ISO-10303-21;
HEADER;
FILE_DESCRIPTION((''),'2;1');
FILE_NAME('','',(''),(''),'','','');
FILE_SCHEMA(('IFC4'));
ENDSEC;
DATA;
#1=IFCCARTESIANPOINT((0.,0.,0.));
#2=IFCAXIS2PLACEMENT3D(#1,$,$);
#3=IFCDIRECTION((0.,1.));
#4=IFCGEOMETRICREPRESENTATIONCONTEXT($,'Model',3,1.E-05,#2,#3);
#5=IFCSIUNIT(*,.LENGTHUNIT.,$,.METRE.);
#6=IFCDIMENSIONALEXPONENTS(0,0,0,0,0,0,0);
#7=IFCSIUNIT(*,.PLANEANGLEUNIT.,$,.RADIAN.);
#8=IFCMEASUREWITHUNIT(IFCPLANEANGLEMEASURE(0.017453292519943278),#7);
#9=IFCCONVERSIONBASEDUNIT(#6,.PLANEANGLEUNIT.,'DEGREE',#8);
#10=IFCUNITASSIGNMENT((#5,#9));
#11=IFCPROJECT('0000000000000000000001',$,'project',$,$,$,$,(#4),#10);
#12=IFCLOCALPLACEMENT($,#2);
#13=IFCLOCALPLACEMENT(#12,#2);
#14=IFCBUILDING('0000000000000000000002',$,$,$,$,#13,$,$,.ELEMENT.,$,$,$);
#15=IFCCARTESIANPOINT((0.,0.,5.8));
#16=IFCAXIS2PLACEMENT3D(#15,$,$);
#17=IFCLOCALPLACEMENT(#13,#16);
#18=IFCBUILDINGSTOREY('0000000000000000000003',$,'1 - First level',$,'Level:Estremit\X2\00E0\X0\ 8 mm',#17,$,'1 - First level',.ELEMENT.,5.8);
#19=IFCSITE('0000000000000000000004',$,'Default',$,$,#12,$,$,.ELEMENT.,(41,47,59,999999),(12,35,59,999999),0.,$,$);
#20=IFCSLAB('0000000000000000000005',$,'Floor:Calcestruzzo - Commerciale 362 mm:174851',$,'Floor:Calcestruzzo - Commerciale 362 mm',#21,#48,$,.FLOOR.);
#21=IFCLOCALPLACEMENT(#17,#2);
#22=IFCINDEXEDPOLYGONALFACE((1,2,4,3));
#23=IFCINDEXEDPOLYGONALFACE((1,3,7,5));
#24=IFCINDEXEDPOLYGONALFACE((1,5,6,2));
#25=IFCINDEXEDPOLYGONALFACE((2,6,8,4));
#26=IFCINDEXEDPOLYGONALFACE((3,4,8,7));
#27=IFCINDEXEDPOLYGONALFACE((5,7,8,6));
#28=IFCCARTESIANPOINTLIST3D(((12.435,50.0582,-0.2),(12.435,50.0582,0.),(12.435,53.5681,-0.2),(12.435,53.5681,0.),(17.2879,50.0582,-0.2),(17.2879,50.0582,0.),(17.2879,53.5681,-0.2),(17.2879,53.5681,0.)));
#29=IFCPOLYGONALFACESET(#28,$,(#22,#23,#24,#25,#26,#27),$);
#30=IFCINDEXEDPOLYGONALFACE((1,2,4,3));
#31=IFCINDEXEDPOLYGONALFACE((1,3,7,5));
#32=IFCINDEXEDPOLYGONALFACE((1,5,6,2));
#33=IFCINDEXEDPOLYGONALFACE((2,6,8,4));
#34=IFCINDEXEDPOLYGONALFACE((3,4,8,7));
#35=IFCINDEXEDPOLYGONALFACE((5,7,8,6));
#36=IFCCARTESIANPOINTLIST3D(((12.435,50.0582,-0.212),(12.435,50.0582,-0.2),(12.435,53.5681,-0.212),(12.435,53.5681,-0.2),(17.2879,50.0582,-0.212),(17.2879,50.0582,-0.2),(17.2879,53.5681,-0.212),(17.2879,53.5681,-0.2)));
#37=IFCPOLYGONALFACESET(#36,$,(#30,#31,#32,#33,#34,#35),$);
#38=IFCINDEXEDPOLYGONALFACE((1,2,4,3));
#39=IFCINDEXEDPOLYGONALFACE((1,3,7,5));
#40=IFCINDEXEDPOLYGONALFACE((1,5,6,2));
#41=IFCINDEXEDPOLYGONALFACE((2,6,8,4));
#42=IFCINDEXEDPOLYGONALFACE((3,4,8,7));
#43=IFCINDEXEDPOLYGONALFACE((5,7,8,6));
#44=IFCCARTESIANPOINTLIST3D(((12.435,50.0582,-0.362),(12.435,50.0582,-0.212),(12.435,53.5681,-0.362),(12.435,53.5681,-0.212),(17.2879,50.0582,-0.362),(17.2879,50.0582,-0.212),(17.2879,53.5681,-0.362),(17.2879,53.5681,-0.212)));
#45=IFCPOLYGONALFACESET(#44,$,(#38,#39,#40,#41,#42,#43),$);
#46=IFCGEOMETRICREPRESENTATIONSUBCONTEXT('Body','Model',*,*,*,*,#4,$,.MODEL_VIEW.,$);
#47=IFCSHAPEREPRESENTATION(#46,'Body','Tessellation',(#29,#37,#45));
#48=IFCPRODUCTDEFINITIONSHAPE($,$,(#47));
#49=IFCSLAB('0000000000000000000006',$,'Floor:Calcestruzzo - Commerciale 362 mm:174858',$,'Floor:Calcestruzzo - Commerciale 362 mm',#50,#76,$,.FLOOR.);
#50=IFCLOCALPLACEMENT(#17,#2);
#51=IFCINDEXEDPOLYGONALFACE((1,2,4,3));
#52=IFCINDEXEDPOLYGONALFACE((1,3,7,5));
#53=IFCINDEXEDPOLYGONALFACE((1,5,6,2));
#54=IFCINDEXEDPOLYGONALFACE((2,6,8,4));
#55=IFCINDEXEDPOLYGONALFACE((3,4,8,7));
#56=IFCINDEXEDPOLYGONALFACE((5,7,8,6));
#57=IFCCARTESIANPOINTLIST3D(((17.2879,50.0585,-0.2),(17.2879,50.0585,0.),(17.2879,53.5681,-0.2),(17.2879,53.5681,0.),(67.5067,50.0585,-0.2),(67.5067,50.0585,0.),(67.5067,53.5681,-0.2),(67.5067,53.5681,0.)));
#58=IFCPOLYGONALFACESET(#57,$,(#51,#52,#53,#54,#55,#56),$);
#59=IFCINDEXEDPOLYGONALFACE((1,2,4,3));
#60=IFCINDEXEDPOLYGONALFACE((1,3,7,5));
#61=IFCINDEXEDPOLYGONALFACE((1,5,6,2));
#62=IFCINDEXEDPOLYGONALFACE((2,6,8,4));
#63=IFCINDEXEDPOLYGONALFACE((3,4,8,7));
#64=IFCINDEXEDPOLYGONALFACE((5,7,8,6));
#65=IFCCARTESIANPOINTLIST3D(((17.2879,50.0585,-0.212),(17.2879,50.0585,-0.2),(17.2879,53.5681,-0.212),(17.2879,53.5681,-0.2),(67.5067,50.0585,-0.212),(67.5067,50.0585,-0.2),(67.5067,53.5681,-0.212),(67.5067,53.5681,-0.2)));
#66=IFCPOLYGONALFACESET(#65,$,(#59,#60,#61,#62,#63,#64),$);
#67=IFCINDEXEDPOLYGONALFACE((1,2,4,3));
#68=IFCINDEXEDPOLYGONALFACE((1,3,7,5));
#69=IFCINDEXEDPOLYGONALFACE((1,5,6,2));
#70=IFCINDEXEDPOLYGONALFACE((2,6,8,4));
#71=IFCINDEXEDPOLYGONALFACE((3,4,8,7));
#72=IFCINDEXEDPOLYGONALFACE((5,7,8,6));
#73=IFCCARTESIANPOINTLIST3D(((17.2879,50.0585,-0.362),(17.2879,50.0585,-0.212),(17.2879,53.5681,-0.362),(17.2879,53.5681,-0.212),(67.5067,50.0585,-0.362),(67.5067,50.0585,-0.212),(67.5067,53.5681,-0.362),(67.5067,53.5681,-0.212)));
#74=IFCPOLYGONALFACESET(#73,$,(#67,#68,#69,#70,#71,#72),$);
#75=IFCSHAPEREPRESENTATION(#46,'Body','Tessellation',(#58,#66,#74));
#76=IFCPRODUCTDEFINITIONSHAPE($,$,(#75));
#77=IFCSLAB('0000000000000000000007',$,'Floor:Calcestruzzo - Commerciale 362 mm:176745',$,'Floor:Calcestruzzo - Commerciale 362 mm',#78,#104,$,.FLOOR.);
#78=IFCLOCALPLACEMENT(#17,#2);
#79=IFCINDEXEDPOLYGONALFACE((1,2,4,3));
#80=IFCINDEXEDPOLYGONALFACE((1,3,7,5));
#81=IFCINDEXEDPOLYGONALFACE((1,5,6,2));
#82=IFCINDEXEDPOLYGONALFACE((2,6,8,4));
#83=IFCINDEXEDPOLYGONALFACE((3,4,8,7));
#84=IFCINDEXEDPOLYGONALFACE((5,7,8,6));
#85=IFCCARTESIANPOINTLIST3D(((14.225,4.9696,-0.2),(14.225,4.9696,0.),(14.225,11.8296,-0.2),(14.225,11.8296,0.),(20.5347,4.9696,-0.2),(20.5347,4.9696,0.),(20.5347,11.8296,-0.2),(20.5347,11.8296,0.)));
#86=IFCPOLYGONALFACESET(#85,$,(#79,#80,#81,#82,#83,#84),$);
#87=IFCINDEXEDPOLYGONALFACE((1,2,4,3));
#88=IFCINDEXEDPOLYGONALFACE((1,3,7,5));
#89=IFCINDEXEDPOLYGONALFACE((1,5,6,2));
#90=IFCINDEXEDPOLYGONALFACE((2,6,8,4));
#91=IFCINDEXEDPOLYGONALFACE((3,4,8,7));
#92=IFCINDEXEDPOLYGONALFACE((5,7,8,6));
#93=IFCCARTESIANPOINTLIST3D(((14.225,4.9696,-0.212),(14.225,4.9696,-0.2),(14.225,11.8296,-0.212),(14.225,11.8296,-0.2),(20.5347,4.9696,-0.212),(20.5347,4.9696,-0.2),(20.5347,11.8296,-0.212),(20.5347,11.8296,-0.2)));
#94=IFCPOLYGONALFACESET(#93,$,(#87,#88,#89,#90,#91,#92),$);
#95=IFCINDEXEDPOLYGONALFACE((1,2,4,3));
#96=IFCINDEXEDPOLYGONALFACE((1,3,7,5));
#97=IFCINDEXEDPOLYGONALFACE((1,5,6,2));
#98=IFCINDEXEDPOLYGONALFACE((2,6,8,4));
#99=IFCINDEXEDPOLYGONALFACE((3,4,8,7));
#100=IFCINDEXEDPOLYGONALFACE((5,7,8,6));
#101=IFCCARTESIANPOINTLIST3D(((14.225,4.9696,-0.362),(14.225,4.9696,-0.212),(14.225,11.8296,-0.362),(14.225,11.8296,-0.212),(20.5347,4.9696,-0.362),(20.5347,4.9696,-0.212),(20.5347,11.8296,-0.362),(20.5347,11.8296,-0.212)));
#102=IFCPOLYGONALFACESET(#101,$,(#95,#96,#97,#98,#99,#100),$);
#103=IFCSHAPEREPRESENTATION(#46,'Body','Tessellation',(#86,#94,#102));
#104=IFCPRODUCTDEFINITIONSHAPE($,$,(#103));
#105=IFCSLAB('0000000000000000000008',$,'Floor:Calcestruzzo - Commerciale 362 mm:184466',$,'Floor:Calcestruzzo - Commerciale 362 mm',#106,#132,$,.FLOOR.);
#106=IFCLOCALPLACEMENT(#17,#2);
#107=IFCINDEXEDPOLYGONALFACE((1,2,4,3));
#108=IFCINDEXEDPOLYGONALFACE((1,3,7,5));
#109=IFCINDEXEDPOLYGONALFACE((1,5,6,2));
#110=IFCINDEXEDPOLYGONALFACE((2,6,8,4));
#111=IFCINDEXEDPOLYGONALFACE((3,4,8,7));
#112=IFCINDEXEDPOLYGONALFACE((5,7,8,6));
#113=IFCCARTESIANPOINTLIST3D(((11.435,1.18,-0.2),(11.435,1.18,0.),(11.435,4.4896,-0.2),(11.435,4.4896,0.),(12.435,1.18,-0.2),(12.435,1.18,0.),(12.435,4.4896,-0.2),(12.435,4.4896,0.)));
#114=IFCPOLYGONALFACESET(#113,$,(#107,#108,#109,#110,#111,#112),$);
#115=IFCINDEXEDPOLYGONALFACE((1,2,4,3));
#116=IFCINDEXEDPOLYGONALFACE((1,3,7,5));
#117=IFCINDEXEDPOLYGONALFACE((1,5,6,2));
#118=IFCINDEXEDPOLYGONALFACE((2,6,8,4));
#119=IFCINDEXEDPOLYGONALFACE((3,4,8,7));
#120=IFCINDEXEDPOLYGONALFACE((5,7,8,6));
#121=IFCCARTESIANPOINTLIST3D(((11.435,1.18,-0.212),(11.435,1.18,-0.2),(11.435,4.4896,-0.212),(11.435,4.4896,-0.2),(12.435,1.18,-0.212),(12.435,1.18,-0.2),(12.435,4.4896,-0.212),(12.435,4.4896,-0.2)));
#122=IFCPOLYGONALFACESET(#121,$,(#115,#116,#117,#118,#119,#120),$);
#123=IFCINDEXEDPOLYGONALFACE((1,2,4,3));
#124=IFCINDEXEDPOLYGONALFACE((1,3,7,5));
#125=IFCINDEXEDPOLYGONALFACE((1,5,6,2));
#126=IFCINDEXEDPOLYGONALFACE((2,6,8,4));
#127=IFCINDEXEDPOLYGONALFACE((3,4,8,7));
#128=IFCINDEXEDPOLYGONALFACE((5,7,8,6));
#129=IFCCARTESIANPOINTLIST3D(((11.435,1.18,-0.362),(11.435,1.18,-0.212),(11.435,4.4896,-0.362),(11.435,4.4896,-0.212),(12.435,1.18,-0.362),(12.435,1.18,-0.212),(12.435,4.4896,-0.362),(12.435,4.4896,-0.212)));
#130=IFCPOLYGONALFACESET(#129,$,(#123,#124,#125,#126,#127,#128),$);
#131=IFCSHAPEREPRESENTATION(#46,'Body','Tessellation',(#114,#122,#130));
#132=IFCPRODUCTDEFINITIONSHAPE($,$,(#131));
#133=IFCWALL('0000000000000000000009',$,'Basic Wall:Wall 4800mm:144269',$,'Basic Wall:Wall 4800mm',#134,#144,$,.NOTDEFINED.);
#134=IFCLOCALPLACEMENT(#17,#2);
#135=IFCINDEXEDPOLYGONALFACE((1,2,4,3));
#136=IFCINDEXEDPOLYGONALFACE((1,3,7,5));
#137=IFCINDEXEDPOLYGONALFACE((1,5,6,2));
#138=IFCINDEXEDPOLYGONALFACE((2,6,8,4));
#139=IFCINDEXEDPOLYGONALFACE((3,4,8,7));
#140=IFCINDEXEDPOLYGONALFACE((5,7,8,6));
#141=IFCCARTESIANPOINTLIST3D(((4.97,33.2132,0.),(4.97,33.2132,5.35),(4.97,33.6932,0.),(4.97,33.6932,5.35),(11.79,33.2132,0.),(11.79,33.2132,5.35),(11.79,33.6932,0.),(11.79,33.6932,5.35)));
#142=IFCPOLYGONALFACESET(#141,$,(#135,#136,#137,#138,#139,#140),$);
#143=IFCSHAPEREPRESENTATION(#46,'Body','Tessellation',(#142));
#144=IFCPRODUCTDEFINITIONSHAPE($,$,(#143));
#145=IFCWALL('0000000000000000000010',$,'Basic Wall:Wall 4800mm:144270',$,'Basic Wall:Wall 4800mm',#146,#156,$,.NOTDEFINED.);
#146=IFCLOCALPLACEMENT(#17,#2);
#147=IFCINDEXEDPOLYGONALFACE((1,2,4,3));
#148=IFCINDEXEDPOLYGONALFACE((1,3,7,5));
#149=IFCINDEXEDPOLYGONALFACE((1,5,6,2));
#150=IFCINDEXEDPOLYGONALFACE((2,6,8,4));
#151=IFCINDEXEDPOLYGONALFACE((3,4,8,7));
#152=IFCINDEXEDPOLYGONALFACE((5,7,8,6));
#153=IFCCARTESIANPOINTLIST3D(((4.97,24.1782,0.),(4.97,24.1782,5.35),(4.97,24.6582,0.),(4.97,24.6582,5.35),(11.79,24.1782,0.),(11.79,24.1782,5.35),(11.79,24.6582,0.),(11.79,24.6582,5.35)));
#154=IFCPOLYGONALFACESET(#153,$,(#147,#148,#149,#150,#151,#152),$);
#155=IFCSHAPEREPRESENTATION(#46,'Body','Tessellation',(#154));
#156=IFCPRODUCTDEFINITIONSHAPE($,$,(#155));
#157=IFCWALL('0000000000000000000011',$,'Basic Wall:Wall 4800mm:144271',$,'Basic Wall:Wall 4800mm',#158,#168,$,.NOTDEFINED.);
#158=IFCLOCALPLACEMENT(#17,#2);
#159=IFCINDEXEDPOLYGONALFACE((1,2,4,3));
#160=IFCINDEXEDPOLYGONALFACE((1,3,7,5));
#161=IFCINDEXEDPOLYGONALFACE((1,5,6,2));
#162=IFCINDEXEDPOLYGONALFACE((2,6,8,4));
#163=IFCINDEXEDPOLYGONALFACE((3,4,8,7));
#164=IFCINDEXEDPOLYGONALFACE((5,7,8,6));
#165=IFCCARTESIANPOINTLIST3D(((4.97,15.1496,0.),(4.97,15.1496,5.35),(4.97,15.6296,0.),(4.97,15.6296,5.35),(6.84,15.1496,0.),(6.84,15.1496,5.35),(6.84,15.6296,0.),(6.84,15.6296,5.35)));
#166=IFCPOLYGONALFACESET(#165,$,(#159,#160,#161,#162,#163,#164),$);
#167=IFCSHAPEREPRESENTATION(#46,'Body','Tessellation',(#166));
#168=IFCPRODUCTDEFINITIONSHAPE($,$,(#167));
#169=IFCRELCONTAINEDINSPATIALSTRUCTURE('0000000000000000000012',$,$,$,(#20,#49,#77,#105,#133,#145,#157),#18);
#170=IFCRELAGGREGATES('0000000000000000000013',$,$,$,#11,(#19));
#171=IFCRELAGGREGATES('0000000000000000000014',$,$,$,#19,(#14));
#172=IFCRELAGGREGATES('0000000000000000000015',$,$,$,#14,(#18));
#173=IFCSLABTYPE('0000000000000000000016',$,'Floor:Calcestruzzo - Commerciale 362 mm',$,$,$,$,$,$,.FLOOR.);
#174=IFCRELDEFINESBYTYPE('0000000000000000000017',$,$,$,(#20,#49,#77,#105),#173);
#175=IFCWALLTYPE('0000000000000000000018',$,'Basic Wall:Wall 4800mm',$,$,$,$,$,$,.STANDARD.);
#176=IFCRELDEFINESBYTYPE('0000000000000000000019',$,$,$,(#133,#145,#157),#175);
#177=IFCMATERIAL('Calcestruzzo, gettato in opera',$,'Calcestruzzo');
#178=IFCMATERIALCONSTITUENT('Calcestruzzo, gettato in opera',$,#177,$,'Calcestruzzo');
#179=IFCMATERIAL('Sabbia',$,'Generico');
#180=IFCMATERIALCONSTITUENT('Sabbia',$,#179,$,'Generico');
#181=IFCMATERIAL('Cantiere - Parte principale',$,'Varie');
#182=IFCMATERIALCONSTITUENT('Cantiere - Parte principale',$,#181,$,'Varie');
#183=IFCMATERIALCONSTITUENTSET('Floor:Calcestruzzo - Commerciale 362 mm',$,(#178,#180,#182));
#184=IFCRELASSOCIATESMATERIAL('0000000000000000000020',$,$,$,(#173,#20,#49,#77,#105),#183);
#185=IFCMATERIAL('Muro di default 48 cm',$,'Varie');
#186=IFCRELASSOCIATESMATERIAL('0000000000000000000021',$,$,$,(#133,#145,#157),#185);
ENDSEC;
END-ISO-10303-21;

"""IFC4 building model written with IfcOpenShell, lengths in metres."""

from ifc_helpers import new_model, entity, si_unit, converted_unit, direction, frame, origin, place, context, subcontext, project, spatial, indexed_curve, outline, extrude, material, constituent, constituent_set, type_object, element, save


model = new_model("IFC4")

# Units and contexts
model_context = context("Model", 3, precision=1e-05, world=origin(), true_north=direction((0.0, 1.0)))
body_context = subcontext(model_context, "Body", "Model", "MODEL_VIEW")
ifc_project = project(units=[si_unit("LENGTHUNIT", "METRE"), converted_unit("PLANEANGLEUNIT", "DEGREE", entity("IfcPlaneAngleMeasure", 0.017453292519943278), si_unit("PLANEANGLEUNIT", "RADIAN"), dimensions=[0, 0, 0, 0, 0, 0, 0])], contexts=[model_context])

# Site, building, storey
site_placement = place(None, origin())
site = spatial("IfcSite", under=ifc_project, at=site_placement, Name="Default", CompositionType="ELEMENT", RefLatitude=(41, 47, 59, 999999), RefLongitude=(12, 35, 59, 999999), RefElevation=0.0)
building_placement = place(site_placement, origin())
building = spatial("IfcBuilding", under=site, at=building_placement, CompositionType="ELEMENT")
storey_placement = place(building_placement, frame((0.0, 0.0, 5.8)))
storey = spatial("IfcBuildingStorey", under=building, at=storey_placement, Name="1 - First level", ObjectType="Level:Estremità 8 mm", LongName="1 - First level", CompositionType="ELEMENT", Elevation=5.8)

# Slabs
ifc_material_1 = material(Name="Calcestruzzo, gettato in opera", Category="Calcestruzzo")
ifc_constituent_1 = constituent(ifc_material_1, Name="Calcestruzzo, gettato in opera", Category="Calcestruzzo")
ifc_material_2 = material(Name="Sabbia", Category="Generico")
ifc_constituent_2 = constituent(ifc_material_2, Name="Sabbia", Category="Generico")
ifc_material_3 = material(Name="Cantiere - Parte principale", Category="Varie")
ifc_constituent_3 = constituent(ifc_material_3, Name="Cantiere - Parte principale", Category="Varie")
ifc_constituent_set = constituent_set(constituents=[ifc_constituent_1, ifc_constituent_2, ifc_constituent_3], Name="Floor:Calcestruzzo - Commerciale 362 mm")
slab_type = type_object("IfcSlabType", Name="Floor:Calcestruzzo - Commerciale 362 mm", PredefinedType="FLOOR", material=ifc_constituent_set)
slab_1_placement = place(storey_placement, origin())
element("IfcSlab", 1, at=slab_1_placement, inside=storey, type_object=slab_type, material=ifc_constituent_set, Name="Floor:Calcestruzzo - Commerciale 362 mm:174851", ObjectType="Floor:Calcestruzzo - Commerciale 362 mm", PredefinedType="FLOOR", context=body_context, shape_type="SweptSolid", body=[
    extrude(outline(indexed_curve([(-1.755, -2.4265), (1.755, -2.4265), (1.755, 2.4265), (-1.755, 2.4265), (-1.755, -2.4265)], self_intersect=False)), frame((14.8615, 51.8132, -0.2), z_axis=(0.0, 0.0, 1.0), x_axis=(0.0, -1.0, 0.0)), (0.0, 0.0, 1.0), 0.2),
    extrude(outline(indexed_curve([(-1.755, -2.4265), (1.755, -2.4265), (1.755, 2.4265), (-1.755, 2.4265), (-1.755, -2.4265)], self_intersect=False)), frame((14.8615, 51.8132, -0.212), z_axis=(0.0, 0.0, 1.0), x_axis=(0.0, -1.0, 0.0)), (0.0, 0.0, 1.0), 0.012),
    extrude(outline(indexed_curve([(-1.755, -2.4265), (1.755, -2.4265), (1.755, 2.4265), (-1.755, 2.4265), (-1.755, -2.4265)], self_intersect=False)), frame((14.8615, 51.8132, -0.362), z_axis=(0.0, 0.0, 1.0), x_axis=(0.0, -1.0, 0.0)), (0.0, 0.0, 1.0), 0.15),
])
slab_2_placement = place(storey_placement, origin())
element("IfcSlab", 2, at=slab_2_placement, inside=storey, type_object=slab_type, material=ifc_constituent_set, Name="Floor:Calcestruzzo - Commerciale 362 mm:174858", ObjectType="Floor:Calcestruzzo - Commerciale 362 mm", PredefinedType="FLOOR", context=body_context, shape_type="SweptSolid", body=[
    extrude(outline(indexed_curve([(-1.7548, -25.1094), (1.7548, -25.1094), (1.7548, 25.1094), (-1.7548, 25.1094), (-1.7548, -25.1094)], self_intersect=False)), frame((42.3973, 51.8133, -0.2), z_axis=(0.0, 0.0, 1.0), x_axis=(0.0, -1.0, 0.0)), (0.0, 0.0, 1.0), 0.2),
    extrude(outline(indexed_curve([(-1.7548, -25.1094), (1.7548, -25.1094), (1.7548, 25.1094), (-1.7548, 25.1094), (-1.7548, -25.1094)], self_intersect=False)), frame((42.3973, 51.8133, -0.212), z_axis=(0.0, 0.0, 1.0), x_axis=(0.0, -1.0, 0.0)), (0.0, 0.0, 1.0), 0.012),
    extrude(outline(indexed_curve([(-1.7548, -25.1094), (1.7548, -25.1094), (1.7548, 25.1094), (-1.7548, 25.1094), (-1.7548, -25.1094)], self_intersect=False)), frame((42.3973, 51.8133, -0.362), z_axis=(0.0, 0.0, 1.0), x_axis=(0.0, -1.0, 0.0)), (0.0, 0.0, 1.0), 0.15),
])
slab_3_placement = place(storey_placement, origin())
element("IfcSlab", 3, at=slab_3_placement, inside=storey, type_object=slab_type, material=ifc_constituent_set, Name="Floor:Calcestruzzo - Commerciale 362 mm:176745", ObjectType="Floor:Calcestruzzo - Commerciale 362 mm", PredefinedType="FLOOR", context=body_context, shape_type="SweptSolid", body=[
    extrude(outline(indexed_curve([(-3.1548, -3.43), (3.1548, -3.43), (3.1548, 3.43), (-3.1548, 3.43), (-3.1548, -3.43)], self_intersect=False)), frame((17.3799, 8.3996, -0.2), z_axis=(0.0, 0.0, 1.0), x_axis=(-1.0, 0.0, 0.0)), (0.0, 0.0, 1.0), 0.2),
    extrude(outline(indexed_curve([(-3.1548, -3.43), (3.1548, -3.43), (3.1548, 3.43), (-3.1548, 3.43), (-3.1548, -3.43)], self_intersect=False)), frame((17.3799, 8.3996, -0.212), z_axis=(0.0, 0.0, 1.0), x_axis=(-1.0, 0.0, 0.0)), (0.0, 0.0, 1.0), 0.012),
    extrude(outline(indexed_curve([(-3.1548, -3.43), (3.1548, -3.43), (3.1548, 3.43), (-3.1548, 3.43), (-3.1548, -3.43)], self_intersect=False)), frame((17.3799, 8.3996, -0.362), z_axis=(0.0, 0.0, 1.0), x_axis=(-1.0, 0.0, 0.0)), (0.0, 0.0, 1.0), 0.15),
])
slab_4_placement = place(storey_placement, origin())
element("IfcSlab", 4, at=slab_4_placement, inside=storey, type_object=slab_type, material=ifc_constituent_set, Name="Floor:Calcestruzzo - Commerciale 362 mm:184466", ObjectType="Floor:Calcestruzzo - Commerciale 362 mm", PredefinedType="FLOOR", context=body_context, shape_type="SweptSolid", body=[
    extrude(outline(indexed_curve([(-1.6548, -0.5), (1.6548, -0.5), (1.6548, 0.5), (-1.6548, 0.5), (-1.6548, -0.5)], self_intersect=False)), frame((11.935, 2.8348, -0.2), z_axis=(0.0, 0.0, 1.0), x_axis=(0.0, 1.0, 0.0)), (0.0, 0.0, 1.0), 0.2),
    extrude(outline(indexed_curve([(-1.6548, -0.5), (1.6548, -0.5), (1.6548, 0.5), (-1.6548, 0.5), (-1.6548, -0.5)], self_intersect=False)), frame((11.935, 2.8348, -0.212), z_axis=(0.0, 0.0, 1.0), x_axis=(0.0, 1.0, 0.0)), (0.0, 0.0, 1.0), 0.012),
    extrude(outline(indexed_curve([(-1.6548, -0.5), (1.6548, -0.5), (1.6548, 0.5), (-1.6548, 0.5), (-1.6548, -0.5)], self_intersect=False)), frame((11.935, 2.8348, -0.362), z_axis=(0.0, 0.0, 1.0), x_axis=(0.0, 1.0, 0.0)), (0.0, 0.0, 1.0), 0.15),
])

# Walls
ifc_material_4 = material(Name="Muro di default 48 cm", Category="Varie")
wall_type = type_object("IfcWallType", Name="Basic Wall:Wall 4800mm", PredefinedType="STANDARD")
wall_1_placement = place(storey_placement, frame((4.97, 33.4532, 0.0)))
element("IfcWall", 5, at=wall_1_placement, inside=storey, type_object=wall_type, material=ifc_material_4, Name="Basic Wall:Wall 4800mm:144269", ObjectType="Basic Wall:Wall 4800mm", PredefinedType="NOTDEFINED", context=body_context, shape_type="SweptSolid", body=[
    extrude(outline(indexed_curve([(6.82, 0.24), (0.0, 0.24), (0.0, -0.24), (6.82, -0.24), (6.82, 0.24)], self_intersect=False)), origin(), (0.0, 0.0, 1.0), 5.35),
])
wall_2_placement = place(storey_placement, frame((4.97, 24.4182, 0.0)))
element("IfcWall", 6, at=wall_2_placement, inside=storey, type_object=wall_type, material=ifc_material_4, Name="Basic Wall:Wall 4800mm:144270", ObjectType="Basic Wall:Wall 4800mm", PredefinedType="NOTDEFINED", context=body_context, shape_type="SweptSolid", body=[
    extrude(outline(indexed_curve([(6.82, 0.24), (0.0, 0.24), (0.0, -0.24), (6.82, -0.24), (6.82, 0.24)], self_intersect=False)), origin(), (0.0, 0.0, 1.0), 5.35),
])
wall_3_placement = place(storey_placement, frame((4.97, 15.3896, 0.0)))
element("IfcWall", 7, at=wall_3_placement, inside=storey, type_object=wall_type, material=ifc_material_4, Name="Basic Wall:Wall 4800mm:144271", ObjectType="Basic Wall:Wall 4800mm", PredefinedType="NOTDEFINED", context=body_context, shape_type="SweptSolid", body=[
    extrude(outline(indexed_curve([(1.87, 0.24), (0.0, 0.24), (0.0, -0.24), (1.87, -0.24), (1.87, 0.24)], self_intersect=False)), origin(), (0.0, 0.0, 1.0), 5.35),
])

save(model, "model.ifc")
